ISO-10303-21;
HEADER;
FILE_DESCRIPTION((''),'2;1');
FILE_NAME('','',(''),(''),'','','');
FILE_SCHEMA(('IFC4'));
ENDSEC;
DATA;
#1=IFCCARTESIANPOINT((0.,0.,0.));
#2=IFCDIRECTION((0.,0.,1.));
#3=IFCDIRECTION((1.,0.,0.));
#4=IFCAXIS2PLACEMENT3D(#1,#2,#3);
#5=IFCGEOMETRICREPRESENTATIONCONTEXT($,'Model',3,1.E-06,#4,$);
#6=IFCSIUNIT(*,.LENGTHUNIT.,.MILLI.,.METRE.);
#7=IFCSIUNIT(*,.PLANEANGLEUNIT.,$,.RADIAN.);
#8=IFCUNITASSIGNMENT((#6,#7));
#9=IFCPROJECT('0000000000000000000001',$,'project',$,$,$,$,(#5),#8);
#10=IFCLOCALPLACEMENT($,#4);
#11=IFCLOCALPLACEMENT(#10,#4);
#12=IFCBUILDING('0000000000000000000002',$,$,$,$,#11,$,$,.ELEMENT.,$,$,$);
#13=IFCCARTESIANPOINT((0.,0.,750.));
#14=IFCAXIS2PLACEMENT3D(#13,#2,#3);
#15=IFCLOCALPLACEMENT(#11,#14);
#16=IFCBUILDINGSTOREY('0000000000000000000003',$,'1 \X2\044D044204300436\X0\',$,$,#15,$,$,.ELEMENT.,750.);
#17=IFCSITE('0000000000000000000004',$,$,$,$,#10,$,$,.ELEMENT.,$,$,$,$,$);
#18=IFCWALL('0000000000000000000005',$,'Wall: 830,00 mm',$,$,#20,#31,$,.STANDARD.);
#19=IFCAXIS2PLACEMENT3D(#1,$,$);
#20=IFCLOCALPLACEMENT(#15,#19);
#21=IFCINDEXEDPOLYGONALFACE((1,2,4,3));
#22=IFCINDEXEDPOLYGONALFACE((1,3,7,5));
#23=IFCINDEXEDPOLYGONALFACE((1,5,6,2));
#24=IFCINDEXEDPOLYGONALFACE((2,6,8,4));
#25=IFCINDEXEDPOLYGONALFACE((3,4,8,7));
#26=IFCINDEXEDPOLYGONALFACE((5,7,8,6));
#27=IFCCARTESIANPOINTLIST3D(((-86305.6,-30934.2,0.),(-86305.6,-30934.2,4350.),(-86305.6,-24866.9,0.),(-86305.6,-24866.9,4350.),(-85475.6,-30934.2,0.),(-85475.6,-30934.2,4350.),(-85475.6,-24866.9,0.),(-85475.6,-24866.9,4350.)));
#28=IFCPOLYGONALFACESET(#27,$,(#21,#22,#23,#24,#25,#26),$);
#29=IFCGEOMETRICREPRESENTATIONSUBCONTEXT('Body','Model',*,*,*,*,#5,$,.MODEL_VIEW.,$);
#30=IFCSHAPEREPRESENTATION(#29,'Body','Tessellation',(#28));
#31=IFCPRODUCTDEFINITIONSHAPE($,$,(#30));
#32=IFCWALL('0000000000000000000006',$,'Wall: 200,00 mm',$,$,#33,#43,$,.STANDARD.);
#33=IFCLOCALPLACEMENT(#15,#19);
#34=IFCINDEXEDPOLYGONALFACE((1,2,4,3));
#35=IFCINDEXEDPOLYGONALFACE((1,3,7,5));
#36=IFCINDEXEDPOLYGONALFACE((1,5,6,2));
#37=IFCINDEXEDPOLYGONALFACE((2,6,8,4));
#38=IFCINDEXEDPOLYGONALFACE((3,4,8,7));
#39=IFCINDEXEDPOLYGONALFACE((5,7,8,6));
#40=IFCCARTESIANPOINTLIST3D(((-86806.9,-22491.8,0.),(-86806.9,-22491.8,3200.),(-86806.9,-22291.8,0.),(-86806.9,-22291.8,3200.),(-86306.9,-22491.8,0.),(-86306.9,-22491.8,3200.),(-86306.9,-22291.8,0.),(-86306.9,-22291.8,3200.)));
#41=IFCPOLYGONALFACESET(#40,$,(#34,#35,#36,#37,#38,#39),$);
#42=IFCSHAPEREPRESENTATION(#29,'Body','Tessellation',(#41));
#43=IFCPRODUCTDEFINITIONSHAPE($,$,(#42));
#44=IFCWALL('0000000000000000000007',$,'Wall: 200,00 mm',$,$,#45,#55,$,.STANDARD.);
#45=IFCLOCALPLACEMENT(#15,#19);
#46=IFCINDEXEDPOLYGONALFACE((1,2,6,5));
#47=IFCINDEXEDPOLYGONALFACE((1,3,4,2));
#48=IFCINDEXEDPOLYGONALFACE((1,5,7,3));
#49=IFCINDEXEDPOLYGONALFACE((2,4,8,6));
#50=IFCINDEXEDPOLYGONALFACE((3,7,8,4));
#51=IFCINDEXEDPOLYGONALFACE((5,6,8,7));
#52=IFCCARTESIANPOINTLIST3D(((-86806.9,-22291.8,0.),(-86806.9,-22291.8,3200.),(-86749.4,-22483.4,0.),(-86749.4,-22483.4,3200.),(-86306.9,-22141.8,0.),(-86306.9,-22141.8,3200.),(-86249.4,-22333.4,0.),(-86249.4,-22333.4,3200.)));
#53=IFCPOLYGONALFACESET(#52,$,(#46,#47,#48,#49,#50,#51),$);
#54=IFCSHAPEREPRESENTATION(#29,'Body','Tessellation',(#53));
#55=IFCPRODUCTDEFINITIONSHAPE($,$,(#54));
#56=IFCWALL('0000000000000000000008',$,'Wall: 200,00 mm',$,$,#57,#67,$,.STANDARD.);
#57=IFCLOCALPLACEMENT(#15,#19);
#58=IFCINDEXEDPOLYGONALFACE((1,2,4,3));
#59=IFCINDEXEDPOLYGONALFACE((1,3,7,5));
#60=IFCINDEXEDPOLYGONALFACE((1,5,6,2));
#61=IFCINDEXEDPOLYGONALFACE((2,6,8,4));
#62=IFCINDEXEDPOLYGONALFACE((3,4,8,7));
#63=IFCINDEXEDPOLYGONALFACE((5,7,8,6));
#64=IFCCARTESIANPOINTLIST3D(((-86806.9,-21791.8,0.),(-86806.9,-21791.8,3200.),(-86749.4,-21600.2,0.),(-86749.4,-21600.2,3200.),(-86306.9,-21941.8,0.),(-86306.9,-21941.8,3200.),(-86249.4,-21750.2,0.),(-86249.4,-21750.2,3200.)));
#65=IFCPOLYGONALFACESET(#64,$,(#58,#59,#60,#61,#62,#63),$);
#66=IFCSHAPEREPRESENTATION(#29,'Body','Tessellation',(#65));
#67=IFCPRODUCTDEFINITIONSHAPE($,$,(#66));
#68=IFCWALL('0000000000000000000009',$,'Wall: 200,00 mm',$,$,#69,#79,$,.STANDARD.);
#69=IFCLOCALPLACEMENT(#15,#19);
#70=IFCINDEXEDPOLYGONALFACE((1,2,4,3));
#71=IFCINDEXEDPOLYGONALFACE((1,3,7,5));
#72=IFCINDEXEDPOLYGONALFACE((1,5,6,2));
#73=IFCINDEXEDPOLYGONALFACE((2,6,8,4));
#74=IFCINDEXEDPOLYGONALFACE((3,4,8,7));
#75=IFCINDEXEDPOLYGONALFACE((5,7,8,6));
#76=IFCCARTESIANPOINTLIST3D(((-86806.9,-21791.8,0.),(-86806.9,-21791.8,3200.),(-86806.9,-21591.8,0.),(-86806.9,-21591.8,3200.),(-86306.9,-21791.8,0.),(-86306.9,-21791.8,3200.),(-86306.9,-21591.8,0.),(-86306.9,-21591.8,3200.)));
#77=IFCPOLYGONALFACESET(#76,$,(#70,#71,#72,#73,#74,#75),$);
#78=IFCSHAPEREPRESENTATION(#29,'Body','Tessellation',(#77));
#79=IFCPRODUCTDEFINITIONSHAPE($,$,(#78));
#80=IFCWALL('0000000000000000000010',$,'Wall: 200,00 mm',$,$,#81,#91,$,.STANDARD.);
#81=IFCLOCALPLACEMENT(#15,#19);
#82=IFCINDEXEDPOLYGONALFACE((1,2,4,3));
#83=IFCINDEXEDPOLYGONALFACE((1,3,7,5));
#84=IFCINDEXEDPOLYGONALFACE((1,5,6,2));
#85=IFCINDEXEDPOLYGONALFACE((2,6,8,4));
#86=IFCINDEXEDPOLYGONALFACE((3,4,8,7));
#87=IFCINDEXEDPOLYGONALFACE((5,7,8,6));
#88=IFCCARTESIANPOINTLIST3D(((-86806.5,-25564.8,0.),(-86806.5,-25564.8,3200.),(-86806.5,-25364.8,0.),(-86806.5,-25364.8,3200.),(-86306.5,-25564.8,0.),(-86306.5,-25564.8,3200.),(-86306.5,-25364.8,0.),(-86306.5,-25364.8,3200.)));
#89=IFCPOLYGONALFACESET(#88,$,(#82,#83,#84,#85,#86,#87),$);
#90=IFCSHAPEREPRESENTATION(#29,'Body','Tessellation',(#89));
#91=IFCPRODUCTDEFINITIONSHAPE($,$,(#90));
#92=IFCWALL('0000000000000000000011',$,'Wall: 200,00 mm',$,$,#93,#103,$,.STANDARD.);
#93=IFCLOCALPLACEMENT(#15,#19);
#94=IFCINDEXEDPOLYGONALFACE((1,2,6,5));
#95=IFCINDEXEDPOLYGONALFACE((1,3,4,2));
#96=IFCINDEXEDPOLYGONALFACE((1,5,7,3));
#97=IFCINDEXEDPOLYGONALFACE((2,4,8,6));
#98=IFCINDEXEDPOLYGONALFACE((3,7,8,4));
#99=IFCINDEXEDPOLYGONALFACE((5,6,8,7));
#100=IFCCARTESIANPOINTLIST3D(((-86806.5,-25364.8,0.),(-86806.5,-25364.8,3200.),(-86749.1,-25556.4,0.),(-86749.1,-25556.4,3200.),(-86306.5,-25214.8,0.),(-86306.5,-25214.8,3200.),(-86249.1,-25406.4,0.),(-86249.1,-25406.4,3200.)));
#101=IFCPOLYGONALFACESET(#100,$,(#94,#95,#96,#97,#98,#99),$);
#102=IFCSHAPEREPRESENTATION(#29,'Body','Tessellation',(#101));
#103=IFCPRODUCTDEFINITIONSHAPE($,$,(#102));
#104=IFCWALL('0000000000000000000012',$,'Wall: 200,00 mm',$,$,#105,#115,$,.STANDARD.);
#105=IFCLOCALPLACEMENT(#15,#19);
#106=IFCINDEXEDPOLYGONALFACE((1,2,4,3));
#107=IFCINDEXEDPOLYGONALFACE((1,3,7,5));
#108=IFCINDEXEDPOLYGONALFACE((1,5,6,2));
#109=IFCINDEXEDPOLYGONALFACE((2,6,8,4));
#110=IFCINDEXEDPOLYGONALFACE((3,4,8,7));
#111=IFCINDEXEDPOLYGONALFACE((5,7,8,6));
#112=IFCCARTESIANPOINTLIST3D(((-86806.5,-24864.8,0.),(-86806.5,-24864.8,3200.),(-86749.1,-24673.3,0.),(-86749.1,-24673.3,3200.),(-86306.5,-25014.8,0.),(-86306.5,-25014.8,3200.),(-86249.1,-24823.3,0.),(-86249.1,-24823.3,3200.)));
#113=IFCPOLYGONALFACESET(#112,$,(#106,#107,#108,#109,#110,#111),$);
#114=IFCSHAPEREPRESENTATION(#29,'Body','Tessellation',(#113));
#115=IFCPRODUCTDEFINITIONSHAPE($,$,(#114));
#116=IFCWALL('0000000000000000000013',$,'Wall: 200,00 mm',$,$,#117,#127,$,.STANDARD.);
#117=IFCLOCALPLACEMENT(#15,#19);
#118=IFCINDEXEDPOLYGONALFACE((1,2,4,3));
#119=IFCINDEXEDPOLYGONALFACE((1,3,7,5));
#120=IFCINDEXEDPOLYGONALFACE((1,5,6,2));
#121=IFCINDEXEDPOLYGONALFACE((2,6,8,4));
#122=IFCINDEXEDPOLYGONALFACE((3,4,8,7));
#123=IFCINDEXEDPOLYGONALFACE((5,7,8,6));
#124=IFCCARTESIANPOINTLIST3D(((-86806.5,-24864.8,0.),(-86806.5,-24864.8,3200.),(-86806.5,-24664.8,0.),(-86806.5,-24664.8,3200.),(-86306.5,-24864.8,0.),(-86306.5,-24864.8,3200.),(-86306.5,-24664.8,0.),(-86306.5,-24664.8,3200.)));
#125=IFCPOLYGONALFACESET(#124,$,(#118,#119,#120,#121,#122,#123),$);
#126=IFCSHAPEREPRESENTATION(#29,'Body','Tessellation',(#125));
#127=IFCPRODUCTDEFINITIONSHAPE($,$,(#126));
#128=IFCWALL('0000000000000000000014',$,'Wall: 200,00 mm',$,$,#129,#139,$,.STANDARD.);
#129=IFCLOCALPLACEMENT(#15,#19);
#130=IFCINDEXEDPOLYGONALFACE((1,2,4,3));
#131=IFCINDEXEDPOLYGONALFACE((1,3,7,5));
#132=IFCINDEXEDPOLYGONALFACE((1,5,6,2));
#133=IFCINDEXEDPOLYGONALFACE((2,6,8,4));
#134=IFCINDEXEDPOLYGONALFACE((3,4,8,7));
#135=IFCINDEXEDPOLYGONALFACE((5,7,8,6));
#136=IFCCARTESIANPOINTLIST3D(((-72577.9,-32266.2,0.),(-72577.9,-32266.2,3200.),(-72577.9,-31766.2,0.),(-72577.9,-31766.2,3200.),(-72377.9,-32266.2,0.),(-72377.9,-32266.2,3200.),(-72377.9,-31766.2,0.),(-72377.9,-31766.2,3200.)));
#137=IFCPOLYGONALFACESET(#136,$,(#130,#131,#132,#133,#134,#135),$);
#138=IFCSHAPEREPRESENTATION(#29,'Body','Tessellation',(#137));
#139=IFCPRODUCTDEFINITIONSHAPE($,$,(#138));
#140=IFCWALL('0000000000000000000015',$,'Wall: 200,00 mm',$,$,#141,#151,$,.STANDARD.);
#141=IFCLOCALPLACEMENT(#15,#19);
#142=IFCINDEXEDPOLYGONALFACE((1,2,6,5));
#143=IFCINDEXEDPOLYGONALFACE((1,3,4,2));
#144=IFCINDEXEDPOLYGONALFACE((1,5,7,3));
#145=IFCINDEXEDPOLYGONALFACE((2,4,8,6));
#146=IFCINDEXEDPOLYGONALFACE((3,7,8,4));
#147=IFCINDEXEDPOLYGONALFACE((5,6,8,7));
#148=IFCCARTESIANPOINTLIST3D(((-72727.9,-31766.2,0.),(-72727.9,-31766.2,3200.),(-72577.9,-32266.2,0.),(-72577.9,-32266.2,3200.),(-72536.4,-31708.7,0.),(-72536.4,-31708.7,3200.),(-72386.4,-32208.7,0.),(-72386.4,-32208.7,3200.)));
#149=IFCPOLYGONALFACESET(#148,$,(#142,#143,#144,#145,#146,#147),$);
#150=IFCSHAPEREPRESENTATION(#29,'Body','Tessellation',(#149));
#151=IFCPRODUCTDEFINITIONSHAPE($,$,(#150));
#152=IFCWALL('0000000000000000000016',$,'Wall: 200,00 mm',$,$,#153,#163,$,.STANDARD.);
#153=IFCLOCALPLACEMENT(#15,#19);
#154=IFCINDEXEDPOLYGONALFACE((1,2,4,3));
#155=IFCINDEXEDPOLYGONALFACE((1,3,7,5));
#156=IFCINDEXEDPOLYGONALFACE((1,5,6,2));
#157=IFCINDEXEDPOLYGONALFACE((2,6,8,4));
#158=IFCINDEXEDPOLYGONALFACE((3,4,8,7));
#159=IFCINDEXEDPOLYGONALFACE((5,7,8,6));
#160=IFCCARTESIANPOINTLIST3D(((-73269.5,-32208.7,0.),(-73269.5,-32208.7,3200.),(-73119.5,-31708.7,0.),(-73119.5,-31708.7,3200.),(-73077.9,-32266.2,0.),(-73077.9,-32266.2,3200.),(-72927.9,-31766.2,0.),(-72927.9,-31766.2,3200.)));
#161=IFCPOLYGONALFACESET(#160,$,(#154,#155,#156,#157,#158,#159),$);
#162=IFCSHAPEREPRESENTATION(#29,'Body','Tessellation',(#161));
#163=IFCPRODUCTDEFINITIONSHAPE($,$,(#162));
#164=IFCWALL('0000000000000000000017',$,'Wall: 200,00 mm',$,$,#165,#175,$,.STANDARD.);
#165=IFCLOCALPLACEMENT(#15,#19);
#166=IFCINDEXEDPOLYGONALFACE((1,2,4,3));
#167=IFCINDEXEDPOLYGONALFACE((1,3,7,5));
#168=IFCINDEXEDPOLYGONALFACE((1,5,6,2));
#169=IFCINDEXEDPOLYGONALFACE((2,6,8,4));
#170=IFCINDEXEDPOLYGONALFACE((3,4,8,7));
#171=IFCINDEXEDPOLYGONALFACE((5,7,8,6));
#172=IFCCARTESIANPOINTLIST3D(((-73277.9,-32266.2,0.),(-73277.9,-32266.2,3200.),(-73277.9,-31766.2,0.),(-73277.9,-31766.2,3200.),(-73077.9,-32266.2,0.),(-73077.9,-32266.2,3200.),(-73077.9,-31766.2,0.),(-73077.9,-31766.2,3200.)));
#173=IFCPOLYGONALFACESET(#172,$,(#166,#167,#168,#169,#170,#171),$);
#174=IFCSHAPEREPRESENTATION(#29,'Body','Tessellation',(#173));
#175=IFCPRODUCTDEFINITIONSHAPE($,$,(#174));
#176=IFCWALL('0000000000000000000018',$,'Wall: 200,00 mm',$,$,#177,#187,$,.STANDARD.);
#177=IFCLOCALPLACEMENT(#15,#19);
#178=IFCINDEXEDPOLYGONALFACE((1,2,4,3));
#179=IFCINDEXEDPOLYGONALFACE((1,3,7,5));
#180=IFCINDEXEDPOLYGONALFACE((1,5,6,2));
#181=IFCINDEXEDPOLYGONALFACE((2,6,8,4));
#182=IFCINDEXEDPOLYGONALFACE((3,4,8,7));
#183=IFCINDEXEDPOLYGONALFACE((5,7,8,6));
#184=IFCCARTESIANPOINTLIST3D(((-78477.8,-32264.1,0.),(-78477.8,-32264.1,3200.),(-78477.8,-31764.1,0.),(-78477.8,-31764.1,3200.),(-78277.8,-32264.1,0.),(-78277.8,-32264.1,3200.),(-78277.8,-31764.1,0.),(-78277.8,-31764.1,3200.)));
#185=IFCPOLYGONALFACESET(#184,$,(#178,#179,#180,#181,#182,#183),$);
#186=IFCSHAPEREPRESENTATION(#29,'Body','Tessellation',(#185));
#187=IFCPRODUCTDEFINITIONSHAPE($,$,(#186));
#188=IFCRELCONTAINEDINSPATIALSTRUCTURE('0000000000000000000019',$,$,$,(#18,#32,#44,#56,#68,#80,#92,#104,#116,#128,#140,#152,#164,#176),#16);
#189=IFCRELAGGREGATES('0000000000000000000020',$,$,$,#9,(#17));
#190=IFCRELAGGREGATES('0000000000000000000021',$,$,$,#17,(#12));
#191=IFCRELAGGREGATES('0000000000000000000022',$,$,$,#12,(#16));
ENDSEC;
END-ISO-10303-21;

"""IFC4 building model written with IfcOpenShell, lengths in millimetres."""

from ifc_helpers import new_model, si_unit, frame, origin_with_axes, place, context, subcontext, project, spatial, line, indexed_curve, outline, extrude, element, save


model = new_model("IFC4")

# Units and contexts
model_context = context("Model", 3, precision=1e-06, world=origin_with_axes())
body_context = subcontext(model_context, "Body", "Model", "MODEL_VIEW")
ifc_project = project(units=[si_unit("LENGTHUNIT", "METRE", prefix="MILLI"), si_unit("PLANEANGLEUNIT", "RADIAN")], contexts=[model_context])

# Site, building, storey
site_placement = place(None, origin_with_axes())
site = spatial("IfcSite", under=ifc_project, at=site_placement, CompositionType="ELEMENT")
building_placement = place(site_placement, origin_with_axes())
building = spatial("IfcBuilding", under=site, at=building_placement, CompositionType="ELEMENT")
storey_placement = place(building_placement, frame((0.0, 0.0, 750.0), z_axis=(0.0, 0.0, 1.0), x_axis=(1.0, 0.0, 0.0)))
storey = spatial("IfcBuildingStorey", under=building, at=storey_placement, Name="1 этаж", CompositionType="ELEMENT", Elevation=750.0)

# Walls
wall_1_placement = place(storey_placement, frame((-86305.6, -24866.9, 0.0), z_axis=(0.0, 0.0, 1.0), x_axis=(0.0, -1.0, 0.0)))
element("IfcWall", 1, at=wall_1_placement, inside=storey, Name="Wall: 830,00 mm", PredefinedType="STANDARD", context=body_context, shape_type="SweptSolid", body=[
    extrude(outline(indexed_curve([(0.0, 0.0), (6067.4, 0.0), (6067.4, 830.0), (0.0, 830.0)], segments=[line(1, 2), line(2, 3), line(3, 4), line(4, 1)])), origin_with_axes(), (0.0, 0.0, 1.0), 4350.0),
])
wall_2_placement = place(storey_placement, frame((-86806.9, -22491.8, 0.0), z_axis=(0.0, 0.0, 1.0), x_axis=(1.0, 0.0, 0.0)))
element("IfcWall", 2, at=wall_2_placement, inside=storey, Name="Wall: 200,00 mm", PredefinedType="STANDARD", context=body_context, shape_type="SweptSolid", body=[
    extrude(outline(indexed_curve([(0.0, 0.0), (500.0, 0.0), (500.0, 200.0), (0.0, 200.0)], segments=[line(1, 2), line(2, 3), line(3, 4), line(4, 1)])), origin_with_axes(), (0.0, 0.0, 1.0), 3200.0),
])
wall_3_placement = place(storey_placement, frame((-86806.9, -22291.8, 0.0), z_axis=(0.0, 0.0, 1.0), x_axis=(0.957826, 0.287348, 0.0)))
element("IfcWall", 3, at=wall_3_placement, inside=storey, Name="Wall: 200,00 mm", PredefinedType="STANDARD", context=body_context, shape_type="SweptSolid", body=[
    extrude(outline(indexed_curve([(0.0, -200.0), (522.0, -200.0), (522.0, 0.0), (0.0, 0.0)], segments=[line(1, 2), line(2, 3), line(3, 4), line(4, 1)])), origin_with_axes(), (0.0, 0.0, 1.0), 3200.0),
])
wall_4_placement = place(storey_placement, frame((-86806.9, -21791.8, 0.0), z_axis=(0.0, 0.0, 1.0), x_axis=(0.957826, -0.287348, 0.0)))
element("IfcWall", 4, at=wall_4_placement, inside=storey, Name="Wall: 200,00 mm", PredefinedType="STANDARD", context=body_context, shape_type="SweptSolid", body=[
    extrude(outline(indexed_curve([(0.0, 0.0), (522.0, 0.0), (522.0, 200.0), (0.0, 200.0)], segments=[line(1, 2), line(2, 3), line(3, 4), line(4, 1)])), origin_with_axes(), (0.0, 0.0, 1.0), 3200.0),
])
wall_5_placement = place(storey_placement, frame((-86806.9, -21591.8, 0.0), z_axis=(0.0, 0.0, 1.0), x_axis=(1.0, 0.0, 0.0)))
element("IfcWall", 5, at=wall_5_placement, inside=storey, Name="Wall: 200,00 mm", PredefinedType="STANDARD", context=body_context, shape_type="SweptSolid", body=[
    extrude(outline(indexed_curve([(0.0, -200.0), (500.0, -200.0), (500.0, 0.0), (0.0, 0.0)], segments=[line(1, 2), line(2, 3), line(3, 4), line(4, 1)])), origin_with_axes(), (0.0, 0.0, 1.0), 3200.0),
])
wall_6_placement = place(storey_placement, frame((-86806.5, -25564.8, 0.0), z_axis=(0.0, 0.0, 1.0), x_axis=(1.0, 0.0, 0.0)))
element("IfcWall", 6, at=wall_6_placement, inside=storey, Name="Wall: 200,00 mm", PredefinedType="STANDARD", context=body_context, shape_type="SweptSolid", body=[
    extrude(outline(indexed_curve([(0.0, 0.0), (500.0, 0.0), (500.0, 200.0), (0.0, 200.0)], segments=[line(1, 2), line(2, 3), line(3, 4), line(4, 1)])), origin_with_axes(), (0.0, 0.0, 1.0), 3200.0),
])
wall_7_placement = place(storey_placement, frame((-86806.5, -25364.8, 0.0), z_axis=(0.0, 0.0, 1.0), x_axis=(0.957826, 0.287348, 0.0)))
element("IfcWall", 7, at=wall_7_placement, inside=storey, Name="Wall: 200,00 mm", PredefinedType="STANDARD", context=body_context, shape_type="SweptSolid", body=[
    extrude(outline(indexed_curve([(0.0, -200.0), (522.0, -200.0), (522.0, 0.0), (0.0, 0.0)], segments=[line(1, 2), line(2, 3), line(3, 4), line(4, 1)])), origin_with_axes(), (0.0, 0.0, 1.0), 3200.0),
])
wall_8_placement = place(storey_placement, frame((-86806.5, -24864.8, 0.0), z_axis=(0.0, 0.0, 1.0), x_axis=(0.957826, -0.287348, 0.0)))
element("IfcWall", 8, at=wall_8_placement, inside=storey, Name="Wall: 200,00 mm", PredefinedType="STANDARD", context=body_context, shape_type="SweptSolid", body=[
    extrude(outline(indexed_curve([(0.0, 0.0), (522.0, 0.0), (522.0, 200.0), (0.0, 200.0)], segments=[line(1, 2), line(2, 3), line(3, 4), line(4, 1)])), origin_with_axes(), (0.0, 0.0, 1.0), 3200.0),
])
wall_9_placement = place(storey_placement, frame((-86806.5, -24664.8, 0.0), z_axis=(0.0, 0.0, 1.0), x_axis=(1.0, 0.0, 0.0)))
element("IfcWall", 9, at=wall_9_placement, inside=storey, Name="Wall: 200,00 mm", PredefinedType="STANDARD", context=body_context, shape_type="SweptSolid", body=[
    extrude(outline(indexed_curve([(0.0, -200.0), (500.0, -200.0), (500.0, 0.0), (0.0, 0.0)], segments=[line(1, 2), line(2, 3), line(3, 4), line(4, 1)])), origin_with_axes(), (0.0, 0.0, 1.0), 3200.0),
])
wall_10_placement = place(storey_placement, frame((-72377.9, -32266.2, 0.0), z_axis=(0.0, 0.0, 1.0), x_axis=(0.0, 1.0, 0.0)))
element("IfcWall", 10, at=wall_10_placement, inside=storey, Name="Wall: 200,00 mm", PredefinedType="STANDARD", context=body_context, shape_type="SweptSolid", body=[
    extrude(outline(indexed_curve([(0.0, 0.0), (500.0, 0.0), (500.0, 200.0), (0.0, 200.0)], segments=[line(1, 2), line(2, 3), line(3, 4), line(4, 1)])), origin_with_axes(), (0.0, 0.0, 1.0), 3200.0),
])
wall_11_placement = place(storey_placement, frame((-72577.9, -32266.2, 0.0), z_axis=(0.0, 0.0, 1.0), x_axis=(-0.287348, 0.957826, 0.0)))
element("IfcWall", 11, at=wall_11_placement, inside=storey, Name="Wall: 200,00 mm", PredefinedType="STANDARD", context=body_context, shape_type="SweptSolid", body=[
    extrude(outline(indexed_curve([(0.0, -200.0), (522.0, -200.0), (522.0, 0.0), (0.0, 0.0)], segments=[line(1, 2), line(2, 3), line(3, 4), line(4, 1)])), origin_with_axes(), (0.0, 0.0, 1.0), 3200.0),
])
wall_12_placement = place(storey_placement, frame((-73077.9, -32266.2, 0.0), z_axis=(0.0, 0.0, 1.0), x_axis=(0.287348, 0.957826, 0.0)))
element("IfcWall", 12, at=wall_12_placement, inside=storey, Name="Wall: 200,00 mm", PredefinedType="STANDARD", context=body_context, shape_type="SweptSolid", body=[
    extrude(outline(indexed_curve([(0.0, 0.0), (522.0, 0.0), (522.0, 200.0), (0.0, 200.0)], segments=[line(1, 2), line(2, 3), line(3, 4), line(4, 1)])), origin_with_axes(), (0.0, 0.0, 1.0), 3200.0),
])
wall_13_placement = place(storey_placement, frame((-73277.9, -32266.2, 0.0), z_axis=(0.0, 0.0, 1.0), x_axis=(0.0, 1.0, 0.0)))
element("IfcWall", 13, at=wall_13_placement, inside=storey, Name="Wall: 200,00 mm", PredefinedType="STANDARD", context=body_context, shape_type="SweptSolid", body=[
    extrude(outline(indexed_curve([(0.0, -200.0), (500.0, -200.0), (500.0, 0.0), (0.0, 0.0)], segments=[line(1, 2), line(2, 3), line(3, 4), line(4, 1)])), origin_with_axes(), (0.0, 0.0, 1.0), 3200.0),
])
wall_14_placement = place(storey_placement, frame((-78277.8, -32264.1, 0.0), z_axis=(0.0, 0.0, 1.0), x_axis=(0.0, 1.0, 0.0)))
element("IfcWall", 14, at=wall_14_placement, inside=storey, Name="Wall: 200,00 mm", PredefinedType="STANDARD", context=body_context, shape_type="SweptSolid", body=[
    extrude(outline(indexed_curve([(0.0, 0.0), (500.0, 0.0), (500.0, 200.0), (0.0, 200.0)], segments=[line(1, 2), line(2, 3), line(3, 4), line(4, 1)])), origin_with_axes(), (0.0, 0.0, 1.0), 3200.0),
])

save(model, "model.ifc")
